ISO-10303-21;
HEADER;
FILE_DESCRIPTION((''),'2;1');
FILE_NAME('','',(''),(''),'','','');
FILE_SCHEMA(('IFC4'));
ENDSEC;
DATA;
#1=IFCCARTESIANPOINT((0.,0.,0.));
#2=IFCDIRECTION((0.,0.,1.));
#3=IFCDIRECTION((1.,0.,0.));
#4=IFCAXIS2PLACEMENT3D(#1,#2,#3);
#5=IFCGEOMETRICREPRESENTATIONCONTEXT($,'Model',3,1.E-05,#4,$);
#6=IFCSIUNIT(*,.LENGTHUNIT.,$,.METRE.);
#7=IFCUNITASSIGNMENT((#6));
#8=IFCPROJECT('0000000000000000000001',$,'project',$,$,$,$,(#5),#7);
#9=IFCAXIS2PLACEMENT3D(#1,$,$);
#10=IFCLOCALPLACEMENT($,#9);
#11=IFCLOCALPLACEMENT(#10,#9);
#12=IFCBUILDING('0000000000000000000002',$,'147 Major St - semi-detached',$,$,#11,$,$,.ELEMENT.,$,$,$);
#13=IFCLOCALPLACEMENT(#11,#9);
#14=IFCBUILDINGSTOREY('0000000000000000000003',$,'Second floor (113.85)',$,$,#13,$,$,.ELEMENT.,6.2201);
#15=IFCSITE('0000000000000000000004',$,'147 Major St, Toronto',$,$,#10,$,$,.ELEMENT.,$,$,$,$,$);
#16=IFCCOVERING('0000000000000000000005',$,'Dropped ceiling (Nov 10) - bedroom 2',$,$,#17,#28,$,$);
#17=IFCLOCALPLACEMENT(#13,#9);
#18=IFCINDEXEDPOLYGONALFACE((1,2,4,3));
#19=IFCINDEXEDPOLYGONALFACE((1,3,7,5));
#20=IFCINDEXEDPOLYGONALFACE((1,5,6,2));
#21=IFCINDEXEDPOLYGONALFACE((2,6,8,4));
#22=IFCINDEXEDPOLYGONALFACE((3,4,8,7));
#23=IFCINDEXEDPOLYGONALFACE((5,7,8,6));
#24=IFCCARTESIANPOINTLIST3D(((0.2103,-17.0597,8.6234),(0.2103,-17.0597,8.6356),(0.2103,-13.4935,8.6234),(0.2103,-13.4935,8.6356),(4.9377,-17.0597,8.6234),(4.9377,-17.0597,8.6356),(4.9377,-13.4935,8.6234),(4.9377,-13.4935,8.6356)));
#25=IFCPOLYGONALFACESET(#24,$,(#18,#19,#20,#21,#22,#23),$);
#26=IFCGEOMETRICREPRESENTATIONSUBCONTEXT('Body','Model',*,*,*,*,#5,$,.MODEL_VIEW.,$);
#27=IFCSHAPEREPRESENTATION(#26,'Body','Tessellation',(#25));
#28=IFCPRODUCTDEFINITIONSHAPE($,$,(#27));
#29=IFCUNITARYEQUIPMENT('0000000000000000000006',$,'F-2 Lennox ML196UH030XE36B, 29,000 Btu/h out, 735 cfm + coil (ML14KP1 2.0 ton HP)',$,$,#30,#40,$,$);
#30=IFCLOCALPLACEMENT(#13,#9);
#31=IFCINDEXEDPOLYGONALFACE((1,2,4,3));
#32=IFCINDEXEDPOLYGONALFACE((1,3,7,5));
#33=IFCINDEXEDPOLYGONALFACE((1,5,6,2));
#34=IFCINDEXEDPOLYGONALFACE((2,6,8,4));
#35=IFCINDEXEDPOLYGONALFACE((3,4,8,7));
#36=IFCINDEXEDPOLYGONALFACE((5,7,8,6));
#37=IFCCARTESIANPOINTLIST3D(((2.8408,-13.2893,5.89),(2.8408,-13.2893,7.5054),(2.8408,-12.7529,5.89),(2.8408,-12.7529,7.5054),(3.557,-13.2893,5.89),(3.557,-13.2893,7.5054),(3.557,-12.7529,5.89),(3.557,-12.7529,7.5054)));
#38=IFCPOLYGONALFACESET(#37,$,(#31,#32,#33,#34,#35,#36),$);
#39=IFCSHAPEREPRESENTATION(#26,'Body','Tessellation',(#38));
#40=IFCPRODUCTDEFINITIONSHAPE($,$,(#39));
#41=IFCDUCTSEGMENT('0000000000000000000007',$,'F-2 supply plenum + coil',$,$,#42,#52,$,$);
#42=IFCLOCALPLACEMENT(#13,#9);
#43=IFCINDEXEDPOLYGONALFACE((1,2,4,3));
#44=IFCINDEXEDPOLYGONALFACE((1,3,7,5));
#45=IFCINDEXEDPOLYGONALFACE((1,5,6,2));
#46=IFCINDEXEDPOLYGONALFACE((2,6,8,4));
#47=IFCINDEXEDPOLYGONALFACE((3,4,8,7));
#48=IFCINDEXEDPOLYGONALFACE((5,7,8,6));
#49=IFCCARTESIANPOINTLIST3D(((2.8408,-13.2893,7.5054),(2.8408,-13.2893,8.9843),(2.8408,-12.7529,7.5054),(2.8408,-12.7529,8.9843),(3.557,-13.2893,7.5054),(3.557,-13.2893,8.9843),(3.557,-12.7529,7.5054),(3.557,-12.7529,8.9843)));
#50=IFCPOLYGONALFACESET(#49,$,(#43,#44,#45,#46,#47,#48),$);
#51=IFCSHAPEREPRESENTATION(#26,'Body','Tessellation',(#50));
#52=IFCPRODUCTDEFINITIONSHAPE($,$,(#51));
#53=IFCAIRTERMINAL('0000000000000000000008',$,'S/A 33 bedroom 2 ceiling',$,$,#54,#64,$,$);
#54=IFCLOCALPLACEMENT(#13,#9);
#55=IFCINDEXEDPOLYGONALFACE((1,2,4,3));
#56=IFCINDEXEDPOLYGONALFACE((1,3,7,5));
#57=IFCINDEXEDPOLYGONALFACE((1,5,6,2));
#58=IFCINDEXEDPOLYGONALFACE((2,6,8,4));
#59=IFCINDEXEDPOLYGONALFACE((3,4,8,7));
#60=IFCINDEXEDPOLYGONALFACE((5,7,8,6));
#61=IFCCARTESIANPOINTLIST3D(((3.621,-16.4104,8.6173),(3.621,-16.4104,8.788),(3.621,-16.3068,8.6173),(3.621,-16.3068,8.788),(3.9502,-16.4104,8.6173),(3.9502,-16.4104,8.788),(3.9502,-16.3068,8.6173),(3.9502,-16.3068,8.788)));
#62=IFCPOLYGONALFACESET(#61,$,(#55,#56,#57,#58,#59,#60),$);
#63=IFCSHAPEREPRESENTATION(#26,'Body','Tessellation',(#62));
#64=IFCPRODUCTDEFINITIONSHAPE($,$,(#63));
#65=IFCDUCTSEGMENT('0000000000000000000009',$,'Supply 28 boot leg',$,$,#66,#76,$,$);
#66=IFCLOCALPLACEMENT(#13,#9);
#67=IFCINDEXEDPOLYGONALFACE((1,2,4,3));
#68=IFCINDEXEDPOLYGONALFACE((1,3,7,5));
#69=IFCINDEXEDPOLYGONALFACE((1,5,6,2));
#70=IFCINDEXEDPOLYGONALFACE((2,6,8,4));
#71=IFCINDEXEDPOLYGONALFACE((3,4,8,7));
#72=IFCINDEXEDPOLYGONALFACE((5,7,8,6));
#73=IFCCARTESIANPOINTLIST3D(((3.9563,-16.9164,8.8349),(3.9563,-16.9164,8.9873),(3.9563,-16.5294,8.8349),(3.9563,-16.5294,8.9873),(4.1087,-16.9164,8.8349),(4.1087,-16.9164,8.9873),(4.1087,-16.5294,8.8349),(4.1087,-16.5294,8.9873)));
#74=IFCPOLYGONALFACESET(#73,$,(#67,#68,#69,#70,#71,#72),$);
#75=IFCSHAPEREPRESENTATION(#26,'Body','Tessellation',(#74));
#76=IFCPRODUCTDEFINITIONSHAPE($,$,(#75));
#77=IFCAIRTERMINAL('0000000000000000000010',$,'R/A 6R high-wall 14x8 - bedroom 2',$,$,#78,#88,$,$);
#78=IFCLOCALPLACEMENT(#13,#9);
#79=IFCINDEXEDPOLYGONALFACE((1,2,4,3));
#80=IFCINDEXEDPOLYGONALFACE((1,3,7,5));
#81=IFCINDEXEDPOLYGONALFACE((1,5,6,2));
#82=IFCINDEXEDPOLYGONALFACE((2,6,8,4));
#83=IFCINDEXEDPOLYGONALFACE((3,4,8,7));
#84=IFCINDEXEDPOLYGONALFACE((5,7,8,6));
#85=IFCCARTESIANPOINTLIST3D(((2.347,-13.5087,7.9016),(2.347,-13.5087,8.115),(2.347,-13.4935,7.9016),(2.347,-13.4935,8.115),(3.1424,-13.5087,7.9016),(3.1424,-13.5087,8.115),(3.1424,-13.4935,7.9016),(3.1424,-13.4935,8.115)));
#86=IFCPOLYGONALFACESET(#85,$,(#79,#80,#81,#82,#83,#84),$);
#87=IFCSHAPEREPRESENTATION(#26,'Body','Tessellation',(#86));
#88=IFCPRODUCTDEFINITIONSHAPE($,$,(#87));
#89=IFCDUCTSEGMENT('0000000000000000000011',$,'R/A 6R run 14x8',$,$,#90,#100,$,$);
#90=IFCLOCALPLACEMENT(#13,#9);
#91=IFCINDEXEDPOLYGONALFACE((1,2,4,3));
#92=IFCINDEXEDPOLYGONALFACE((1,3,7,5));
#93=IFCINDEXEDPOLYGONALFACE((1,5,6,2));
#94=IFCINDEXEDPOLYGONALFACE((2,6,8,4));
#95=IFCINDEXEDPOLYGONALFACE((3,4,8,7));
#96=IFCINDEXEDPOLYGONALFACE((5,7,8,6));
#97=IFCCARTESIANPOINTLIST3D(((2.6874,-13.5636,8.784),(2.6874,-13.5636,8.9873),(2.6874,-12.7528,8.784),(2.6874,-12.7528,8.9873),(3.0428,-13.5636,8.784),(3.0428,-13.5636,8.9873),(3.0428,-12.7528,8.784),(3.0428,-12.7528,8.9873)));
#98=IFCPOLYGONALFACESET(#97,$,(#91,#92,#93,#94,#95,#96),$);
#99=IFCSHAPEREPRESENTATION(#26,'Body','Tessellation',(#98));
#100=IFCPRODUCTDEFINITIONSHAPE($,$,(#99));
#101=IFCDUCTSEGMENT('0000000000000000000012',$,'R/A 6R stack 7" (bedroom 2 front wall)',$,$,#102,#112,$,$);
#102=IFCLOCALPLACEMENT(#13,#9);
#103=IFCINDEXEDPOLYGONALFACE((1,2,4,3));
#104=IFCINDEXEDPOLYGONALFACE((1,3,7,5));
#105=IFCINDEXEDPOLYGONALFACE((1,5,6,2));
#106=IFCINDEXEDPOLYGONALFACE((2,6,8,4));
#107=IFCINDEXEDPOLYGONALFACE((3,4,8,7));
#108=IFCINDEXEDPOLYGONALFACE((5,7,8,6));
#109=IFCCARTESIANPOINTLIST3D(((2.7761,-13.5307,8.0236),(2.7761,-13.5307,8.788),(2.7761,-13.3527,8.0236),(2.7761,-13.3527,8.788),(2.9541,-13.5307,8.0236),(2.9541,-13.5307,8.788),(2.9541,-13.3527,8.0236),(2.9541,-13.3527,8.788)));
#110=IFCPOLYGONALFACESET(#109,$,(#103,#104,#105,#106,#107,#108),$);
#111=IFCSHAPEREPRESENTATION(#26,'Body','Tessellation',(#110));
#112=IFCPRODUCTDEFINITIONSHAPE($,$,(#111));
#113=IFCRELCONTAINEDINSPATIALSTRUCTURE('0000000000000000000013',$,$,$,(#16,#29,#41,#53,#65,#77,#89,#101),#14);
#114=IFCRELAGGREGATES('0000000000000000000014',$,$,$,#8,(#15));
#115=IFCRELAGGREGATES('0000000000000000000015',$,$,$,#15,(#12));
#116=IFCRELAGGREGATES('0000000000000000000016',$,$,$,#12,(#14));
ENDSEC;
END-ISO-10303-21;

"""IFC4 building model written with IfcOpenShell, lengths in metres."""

from ifc_helpers import new_model, si_unit, frame, origin, origin_with_axes, place, context, subcontext, project, spatial, rectangle, extrude, element, save


model = new_model("IFC4")

# Units and contexts
model_context = context("Model", 3, precision=1e-05, world=origin_with_axes())
body_context = subcontext(model_context, "Body", "Model", "MODEL_VIEW")
ifc_project = project(units=[si_unit("LENGTHUNIT", "METRE")], contexts=[model_context])

# Site, building, storey
site_placement = place(None, origin())
site = spatial("IfcSite", under=ifc_project, at=site_placement, Name="147 Major St, Toronto", CompositionType="ELEMENT")
building_placement = place(site_placement, origin())
building = spatial("IfcBuilding", under=site, at=building_placement, Name="147 Major St - semi-detached", CompositionType="ELEMENT")
storey_placement = place(building_placement, origin())
storey = spatial("IfcBuildingStorey", under=building, at=storey_placement, Name="Second floor (113.85)", CompositionType="ELEMENT", Elevation=6.2201)

# Covering
for number, where, name in (
    (1, (2.574, -15.2766, 8.6234), "Dropped ceiling (Nov 10) - bedroom 2"),
):
    element("IfcCovering", number, at=place(storey_placement, frame(where)), inside=storey, Name=name, context=body_context, shape_type="SweptSolid", body=[
        extrude(rectangle(XDim=4.7274, YDim=3.5662), origin_with_axes(), (0.0, 0.0, 1.0), 0.0122),
    ])

# Unitary equipment
unitary_equipment_placement = place(storey_placement, frame((3.1989, -13.0211, 5.89)))
element("IfcUnitaryEquipment", 2, at=unitary_equipment_placement, inside=storey, Name="F-2 Lennox ML196UH030XE36B, 29,000 Btu/h out, 735 cfm + coil (ML14KP1 2.0 ton HP)", context=body_context, shape_type="SweptSolid", body=[
    extrude(rectangle(XDim=0.7163, YDim=0.5364), origin_with_axes(), (0.0, 0.0, 1.0), 1.6154),
])

# Duct segment
duct_segment_1_placement = place(storey_placement, frame((3.1989, -13.0211, 7.5054)))
element("IfcDuctSegment", 3, at=duct_segment_1_placement, inside=storey, Name="F-2 supply plenum + coil", context=body_context, shape_type="SweptSolid", body=[
    extrude(rectangle(XDim=0.7163, YDim=0.5364), origin_with_axes(), (0.0, 0.0, 1.0), 1.4789),
])

# Air terminal
air_terminal_1_placement = place(storey_placement, frame((3.7856, -16.3586, 8.6173)))
element("IfcAirTerminal", 4, at=air_terminal_1_placement, inside=storey, Name="S/A 33 bedroom 2 ceiling", context=body_context, shape_type="SweptSolid", body=[
    extrude(rectangle(XDim=0.3292, YDim=0.1036), origin_with_axes(), (0.0, 0.0, 1.0), 0.1707),
])

# Duct segment
duct_segment_2_placement = place(storey_placement, frame((4.0325, -16.7229, 8.8349)))
element("IfcDuctSegment", 5, at=duct_segment_2_placement, inside=storey, Name="Supply 28 boot leg", context=body_context, shape_type="SweptSolid", body=[
    extrude(rectangle(XDim=0.1524, YDim=0.3871), origin_with_axes(), (0.0, 0.0, 1.0), 0.1524),
])

# Air terminal
air_terminal_2_placement = place(storey_placement, frame((2.7447, -13.5011, 7.9016)))
element("IfcAirTerminal", 6, at=air_terminal_2_placement, inside=storey, Name="R/A 6R high-wall 14x8 - bedroom 2", context=body_context, shape_type="SweptSolid", body=[
    extrude(rectangle(XDim=0.7955, YDim=0.0152), origin_with_axes(), (0.0, 0.0, 1.0), 0.2134),
])

# Duct segments
duct_segment_3_placement = place(storey_placement, frame((2.8651, -13.1582, 8.784)))
element("IfcDuctSegment", 7, at=duct_segment_3_placement, inside=storey, Name="R/A 6R run 14x8", context=body_context, shape_type="SweptSolid", body=[
    extrude(rectangle(XDim=0.3554, YDim=0.8108), origin_with_axes(), (0.0, 0.0, 1.0), 0.2033),
])
duct_segment_4_placement = place(storey_placement, frame((2.8651, -13.4417, 8.0236)))
element("IfcDuctSegment", 8, at=duct_segment_4_placement, inside=storey, Name="R/A 6R stack 7\" (bedroom 2 front wall)", context=body_context, shape_type="SweptSolid", body=[
    extrude(rectangle(XDim=0.178, YDim=0.178), origin_with_axes(), (0.0, 0.0, 1.0), 0.7644),
])

save(model, "model.ifc")
